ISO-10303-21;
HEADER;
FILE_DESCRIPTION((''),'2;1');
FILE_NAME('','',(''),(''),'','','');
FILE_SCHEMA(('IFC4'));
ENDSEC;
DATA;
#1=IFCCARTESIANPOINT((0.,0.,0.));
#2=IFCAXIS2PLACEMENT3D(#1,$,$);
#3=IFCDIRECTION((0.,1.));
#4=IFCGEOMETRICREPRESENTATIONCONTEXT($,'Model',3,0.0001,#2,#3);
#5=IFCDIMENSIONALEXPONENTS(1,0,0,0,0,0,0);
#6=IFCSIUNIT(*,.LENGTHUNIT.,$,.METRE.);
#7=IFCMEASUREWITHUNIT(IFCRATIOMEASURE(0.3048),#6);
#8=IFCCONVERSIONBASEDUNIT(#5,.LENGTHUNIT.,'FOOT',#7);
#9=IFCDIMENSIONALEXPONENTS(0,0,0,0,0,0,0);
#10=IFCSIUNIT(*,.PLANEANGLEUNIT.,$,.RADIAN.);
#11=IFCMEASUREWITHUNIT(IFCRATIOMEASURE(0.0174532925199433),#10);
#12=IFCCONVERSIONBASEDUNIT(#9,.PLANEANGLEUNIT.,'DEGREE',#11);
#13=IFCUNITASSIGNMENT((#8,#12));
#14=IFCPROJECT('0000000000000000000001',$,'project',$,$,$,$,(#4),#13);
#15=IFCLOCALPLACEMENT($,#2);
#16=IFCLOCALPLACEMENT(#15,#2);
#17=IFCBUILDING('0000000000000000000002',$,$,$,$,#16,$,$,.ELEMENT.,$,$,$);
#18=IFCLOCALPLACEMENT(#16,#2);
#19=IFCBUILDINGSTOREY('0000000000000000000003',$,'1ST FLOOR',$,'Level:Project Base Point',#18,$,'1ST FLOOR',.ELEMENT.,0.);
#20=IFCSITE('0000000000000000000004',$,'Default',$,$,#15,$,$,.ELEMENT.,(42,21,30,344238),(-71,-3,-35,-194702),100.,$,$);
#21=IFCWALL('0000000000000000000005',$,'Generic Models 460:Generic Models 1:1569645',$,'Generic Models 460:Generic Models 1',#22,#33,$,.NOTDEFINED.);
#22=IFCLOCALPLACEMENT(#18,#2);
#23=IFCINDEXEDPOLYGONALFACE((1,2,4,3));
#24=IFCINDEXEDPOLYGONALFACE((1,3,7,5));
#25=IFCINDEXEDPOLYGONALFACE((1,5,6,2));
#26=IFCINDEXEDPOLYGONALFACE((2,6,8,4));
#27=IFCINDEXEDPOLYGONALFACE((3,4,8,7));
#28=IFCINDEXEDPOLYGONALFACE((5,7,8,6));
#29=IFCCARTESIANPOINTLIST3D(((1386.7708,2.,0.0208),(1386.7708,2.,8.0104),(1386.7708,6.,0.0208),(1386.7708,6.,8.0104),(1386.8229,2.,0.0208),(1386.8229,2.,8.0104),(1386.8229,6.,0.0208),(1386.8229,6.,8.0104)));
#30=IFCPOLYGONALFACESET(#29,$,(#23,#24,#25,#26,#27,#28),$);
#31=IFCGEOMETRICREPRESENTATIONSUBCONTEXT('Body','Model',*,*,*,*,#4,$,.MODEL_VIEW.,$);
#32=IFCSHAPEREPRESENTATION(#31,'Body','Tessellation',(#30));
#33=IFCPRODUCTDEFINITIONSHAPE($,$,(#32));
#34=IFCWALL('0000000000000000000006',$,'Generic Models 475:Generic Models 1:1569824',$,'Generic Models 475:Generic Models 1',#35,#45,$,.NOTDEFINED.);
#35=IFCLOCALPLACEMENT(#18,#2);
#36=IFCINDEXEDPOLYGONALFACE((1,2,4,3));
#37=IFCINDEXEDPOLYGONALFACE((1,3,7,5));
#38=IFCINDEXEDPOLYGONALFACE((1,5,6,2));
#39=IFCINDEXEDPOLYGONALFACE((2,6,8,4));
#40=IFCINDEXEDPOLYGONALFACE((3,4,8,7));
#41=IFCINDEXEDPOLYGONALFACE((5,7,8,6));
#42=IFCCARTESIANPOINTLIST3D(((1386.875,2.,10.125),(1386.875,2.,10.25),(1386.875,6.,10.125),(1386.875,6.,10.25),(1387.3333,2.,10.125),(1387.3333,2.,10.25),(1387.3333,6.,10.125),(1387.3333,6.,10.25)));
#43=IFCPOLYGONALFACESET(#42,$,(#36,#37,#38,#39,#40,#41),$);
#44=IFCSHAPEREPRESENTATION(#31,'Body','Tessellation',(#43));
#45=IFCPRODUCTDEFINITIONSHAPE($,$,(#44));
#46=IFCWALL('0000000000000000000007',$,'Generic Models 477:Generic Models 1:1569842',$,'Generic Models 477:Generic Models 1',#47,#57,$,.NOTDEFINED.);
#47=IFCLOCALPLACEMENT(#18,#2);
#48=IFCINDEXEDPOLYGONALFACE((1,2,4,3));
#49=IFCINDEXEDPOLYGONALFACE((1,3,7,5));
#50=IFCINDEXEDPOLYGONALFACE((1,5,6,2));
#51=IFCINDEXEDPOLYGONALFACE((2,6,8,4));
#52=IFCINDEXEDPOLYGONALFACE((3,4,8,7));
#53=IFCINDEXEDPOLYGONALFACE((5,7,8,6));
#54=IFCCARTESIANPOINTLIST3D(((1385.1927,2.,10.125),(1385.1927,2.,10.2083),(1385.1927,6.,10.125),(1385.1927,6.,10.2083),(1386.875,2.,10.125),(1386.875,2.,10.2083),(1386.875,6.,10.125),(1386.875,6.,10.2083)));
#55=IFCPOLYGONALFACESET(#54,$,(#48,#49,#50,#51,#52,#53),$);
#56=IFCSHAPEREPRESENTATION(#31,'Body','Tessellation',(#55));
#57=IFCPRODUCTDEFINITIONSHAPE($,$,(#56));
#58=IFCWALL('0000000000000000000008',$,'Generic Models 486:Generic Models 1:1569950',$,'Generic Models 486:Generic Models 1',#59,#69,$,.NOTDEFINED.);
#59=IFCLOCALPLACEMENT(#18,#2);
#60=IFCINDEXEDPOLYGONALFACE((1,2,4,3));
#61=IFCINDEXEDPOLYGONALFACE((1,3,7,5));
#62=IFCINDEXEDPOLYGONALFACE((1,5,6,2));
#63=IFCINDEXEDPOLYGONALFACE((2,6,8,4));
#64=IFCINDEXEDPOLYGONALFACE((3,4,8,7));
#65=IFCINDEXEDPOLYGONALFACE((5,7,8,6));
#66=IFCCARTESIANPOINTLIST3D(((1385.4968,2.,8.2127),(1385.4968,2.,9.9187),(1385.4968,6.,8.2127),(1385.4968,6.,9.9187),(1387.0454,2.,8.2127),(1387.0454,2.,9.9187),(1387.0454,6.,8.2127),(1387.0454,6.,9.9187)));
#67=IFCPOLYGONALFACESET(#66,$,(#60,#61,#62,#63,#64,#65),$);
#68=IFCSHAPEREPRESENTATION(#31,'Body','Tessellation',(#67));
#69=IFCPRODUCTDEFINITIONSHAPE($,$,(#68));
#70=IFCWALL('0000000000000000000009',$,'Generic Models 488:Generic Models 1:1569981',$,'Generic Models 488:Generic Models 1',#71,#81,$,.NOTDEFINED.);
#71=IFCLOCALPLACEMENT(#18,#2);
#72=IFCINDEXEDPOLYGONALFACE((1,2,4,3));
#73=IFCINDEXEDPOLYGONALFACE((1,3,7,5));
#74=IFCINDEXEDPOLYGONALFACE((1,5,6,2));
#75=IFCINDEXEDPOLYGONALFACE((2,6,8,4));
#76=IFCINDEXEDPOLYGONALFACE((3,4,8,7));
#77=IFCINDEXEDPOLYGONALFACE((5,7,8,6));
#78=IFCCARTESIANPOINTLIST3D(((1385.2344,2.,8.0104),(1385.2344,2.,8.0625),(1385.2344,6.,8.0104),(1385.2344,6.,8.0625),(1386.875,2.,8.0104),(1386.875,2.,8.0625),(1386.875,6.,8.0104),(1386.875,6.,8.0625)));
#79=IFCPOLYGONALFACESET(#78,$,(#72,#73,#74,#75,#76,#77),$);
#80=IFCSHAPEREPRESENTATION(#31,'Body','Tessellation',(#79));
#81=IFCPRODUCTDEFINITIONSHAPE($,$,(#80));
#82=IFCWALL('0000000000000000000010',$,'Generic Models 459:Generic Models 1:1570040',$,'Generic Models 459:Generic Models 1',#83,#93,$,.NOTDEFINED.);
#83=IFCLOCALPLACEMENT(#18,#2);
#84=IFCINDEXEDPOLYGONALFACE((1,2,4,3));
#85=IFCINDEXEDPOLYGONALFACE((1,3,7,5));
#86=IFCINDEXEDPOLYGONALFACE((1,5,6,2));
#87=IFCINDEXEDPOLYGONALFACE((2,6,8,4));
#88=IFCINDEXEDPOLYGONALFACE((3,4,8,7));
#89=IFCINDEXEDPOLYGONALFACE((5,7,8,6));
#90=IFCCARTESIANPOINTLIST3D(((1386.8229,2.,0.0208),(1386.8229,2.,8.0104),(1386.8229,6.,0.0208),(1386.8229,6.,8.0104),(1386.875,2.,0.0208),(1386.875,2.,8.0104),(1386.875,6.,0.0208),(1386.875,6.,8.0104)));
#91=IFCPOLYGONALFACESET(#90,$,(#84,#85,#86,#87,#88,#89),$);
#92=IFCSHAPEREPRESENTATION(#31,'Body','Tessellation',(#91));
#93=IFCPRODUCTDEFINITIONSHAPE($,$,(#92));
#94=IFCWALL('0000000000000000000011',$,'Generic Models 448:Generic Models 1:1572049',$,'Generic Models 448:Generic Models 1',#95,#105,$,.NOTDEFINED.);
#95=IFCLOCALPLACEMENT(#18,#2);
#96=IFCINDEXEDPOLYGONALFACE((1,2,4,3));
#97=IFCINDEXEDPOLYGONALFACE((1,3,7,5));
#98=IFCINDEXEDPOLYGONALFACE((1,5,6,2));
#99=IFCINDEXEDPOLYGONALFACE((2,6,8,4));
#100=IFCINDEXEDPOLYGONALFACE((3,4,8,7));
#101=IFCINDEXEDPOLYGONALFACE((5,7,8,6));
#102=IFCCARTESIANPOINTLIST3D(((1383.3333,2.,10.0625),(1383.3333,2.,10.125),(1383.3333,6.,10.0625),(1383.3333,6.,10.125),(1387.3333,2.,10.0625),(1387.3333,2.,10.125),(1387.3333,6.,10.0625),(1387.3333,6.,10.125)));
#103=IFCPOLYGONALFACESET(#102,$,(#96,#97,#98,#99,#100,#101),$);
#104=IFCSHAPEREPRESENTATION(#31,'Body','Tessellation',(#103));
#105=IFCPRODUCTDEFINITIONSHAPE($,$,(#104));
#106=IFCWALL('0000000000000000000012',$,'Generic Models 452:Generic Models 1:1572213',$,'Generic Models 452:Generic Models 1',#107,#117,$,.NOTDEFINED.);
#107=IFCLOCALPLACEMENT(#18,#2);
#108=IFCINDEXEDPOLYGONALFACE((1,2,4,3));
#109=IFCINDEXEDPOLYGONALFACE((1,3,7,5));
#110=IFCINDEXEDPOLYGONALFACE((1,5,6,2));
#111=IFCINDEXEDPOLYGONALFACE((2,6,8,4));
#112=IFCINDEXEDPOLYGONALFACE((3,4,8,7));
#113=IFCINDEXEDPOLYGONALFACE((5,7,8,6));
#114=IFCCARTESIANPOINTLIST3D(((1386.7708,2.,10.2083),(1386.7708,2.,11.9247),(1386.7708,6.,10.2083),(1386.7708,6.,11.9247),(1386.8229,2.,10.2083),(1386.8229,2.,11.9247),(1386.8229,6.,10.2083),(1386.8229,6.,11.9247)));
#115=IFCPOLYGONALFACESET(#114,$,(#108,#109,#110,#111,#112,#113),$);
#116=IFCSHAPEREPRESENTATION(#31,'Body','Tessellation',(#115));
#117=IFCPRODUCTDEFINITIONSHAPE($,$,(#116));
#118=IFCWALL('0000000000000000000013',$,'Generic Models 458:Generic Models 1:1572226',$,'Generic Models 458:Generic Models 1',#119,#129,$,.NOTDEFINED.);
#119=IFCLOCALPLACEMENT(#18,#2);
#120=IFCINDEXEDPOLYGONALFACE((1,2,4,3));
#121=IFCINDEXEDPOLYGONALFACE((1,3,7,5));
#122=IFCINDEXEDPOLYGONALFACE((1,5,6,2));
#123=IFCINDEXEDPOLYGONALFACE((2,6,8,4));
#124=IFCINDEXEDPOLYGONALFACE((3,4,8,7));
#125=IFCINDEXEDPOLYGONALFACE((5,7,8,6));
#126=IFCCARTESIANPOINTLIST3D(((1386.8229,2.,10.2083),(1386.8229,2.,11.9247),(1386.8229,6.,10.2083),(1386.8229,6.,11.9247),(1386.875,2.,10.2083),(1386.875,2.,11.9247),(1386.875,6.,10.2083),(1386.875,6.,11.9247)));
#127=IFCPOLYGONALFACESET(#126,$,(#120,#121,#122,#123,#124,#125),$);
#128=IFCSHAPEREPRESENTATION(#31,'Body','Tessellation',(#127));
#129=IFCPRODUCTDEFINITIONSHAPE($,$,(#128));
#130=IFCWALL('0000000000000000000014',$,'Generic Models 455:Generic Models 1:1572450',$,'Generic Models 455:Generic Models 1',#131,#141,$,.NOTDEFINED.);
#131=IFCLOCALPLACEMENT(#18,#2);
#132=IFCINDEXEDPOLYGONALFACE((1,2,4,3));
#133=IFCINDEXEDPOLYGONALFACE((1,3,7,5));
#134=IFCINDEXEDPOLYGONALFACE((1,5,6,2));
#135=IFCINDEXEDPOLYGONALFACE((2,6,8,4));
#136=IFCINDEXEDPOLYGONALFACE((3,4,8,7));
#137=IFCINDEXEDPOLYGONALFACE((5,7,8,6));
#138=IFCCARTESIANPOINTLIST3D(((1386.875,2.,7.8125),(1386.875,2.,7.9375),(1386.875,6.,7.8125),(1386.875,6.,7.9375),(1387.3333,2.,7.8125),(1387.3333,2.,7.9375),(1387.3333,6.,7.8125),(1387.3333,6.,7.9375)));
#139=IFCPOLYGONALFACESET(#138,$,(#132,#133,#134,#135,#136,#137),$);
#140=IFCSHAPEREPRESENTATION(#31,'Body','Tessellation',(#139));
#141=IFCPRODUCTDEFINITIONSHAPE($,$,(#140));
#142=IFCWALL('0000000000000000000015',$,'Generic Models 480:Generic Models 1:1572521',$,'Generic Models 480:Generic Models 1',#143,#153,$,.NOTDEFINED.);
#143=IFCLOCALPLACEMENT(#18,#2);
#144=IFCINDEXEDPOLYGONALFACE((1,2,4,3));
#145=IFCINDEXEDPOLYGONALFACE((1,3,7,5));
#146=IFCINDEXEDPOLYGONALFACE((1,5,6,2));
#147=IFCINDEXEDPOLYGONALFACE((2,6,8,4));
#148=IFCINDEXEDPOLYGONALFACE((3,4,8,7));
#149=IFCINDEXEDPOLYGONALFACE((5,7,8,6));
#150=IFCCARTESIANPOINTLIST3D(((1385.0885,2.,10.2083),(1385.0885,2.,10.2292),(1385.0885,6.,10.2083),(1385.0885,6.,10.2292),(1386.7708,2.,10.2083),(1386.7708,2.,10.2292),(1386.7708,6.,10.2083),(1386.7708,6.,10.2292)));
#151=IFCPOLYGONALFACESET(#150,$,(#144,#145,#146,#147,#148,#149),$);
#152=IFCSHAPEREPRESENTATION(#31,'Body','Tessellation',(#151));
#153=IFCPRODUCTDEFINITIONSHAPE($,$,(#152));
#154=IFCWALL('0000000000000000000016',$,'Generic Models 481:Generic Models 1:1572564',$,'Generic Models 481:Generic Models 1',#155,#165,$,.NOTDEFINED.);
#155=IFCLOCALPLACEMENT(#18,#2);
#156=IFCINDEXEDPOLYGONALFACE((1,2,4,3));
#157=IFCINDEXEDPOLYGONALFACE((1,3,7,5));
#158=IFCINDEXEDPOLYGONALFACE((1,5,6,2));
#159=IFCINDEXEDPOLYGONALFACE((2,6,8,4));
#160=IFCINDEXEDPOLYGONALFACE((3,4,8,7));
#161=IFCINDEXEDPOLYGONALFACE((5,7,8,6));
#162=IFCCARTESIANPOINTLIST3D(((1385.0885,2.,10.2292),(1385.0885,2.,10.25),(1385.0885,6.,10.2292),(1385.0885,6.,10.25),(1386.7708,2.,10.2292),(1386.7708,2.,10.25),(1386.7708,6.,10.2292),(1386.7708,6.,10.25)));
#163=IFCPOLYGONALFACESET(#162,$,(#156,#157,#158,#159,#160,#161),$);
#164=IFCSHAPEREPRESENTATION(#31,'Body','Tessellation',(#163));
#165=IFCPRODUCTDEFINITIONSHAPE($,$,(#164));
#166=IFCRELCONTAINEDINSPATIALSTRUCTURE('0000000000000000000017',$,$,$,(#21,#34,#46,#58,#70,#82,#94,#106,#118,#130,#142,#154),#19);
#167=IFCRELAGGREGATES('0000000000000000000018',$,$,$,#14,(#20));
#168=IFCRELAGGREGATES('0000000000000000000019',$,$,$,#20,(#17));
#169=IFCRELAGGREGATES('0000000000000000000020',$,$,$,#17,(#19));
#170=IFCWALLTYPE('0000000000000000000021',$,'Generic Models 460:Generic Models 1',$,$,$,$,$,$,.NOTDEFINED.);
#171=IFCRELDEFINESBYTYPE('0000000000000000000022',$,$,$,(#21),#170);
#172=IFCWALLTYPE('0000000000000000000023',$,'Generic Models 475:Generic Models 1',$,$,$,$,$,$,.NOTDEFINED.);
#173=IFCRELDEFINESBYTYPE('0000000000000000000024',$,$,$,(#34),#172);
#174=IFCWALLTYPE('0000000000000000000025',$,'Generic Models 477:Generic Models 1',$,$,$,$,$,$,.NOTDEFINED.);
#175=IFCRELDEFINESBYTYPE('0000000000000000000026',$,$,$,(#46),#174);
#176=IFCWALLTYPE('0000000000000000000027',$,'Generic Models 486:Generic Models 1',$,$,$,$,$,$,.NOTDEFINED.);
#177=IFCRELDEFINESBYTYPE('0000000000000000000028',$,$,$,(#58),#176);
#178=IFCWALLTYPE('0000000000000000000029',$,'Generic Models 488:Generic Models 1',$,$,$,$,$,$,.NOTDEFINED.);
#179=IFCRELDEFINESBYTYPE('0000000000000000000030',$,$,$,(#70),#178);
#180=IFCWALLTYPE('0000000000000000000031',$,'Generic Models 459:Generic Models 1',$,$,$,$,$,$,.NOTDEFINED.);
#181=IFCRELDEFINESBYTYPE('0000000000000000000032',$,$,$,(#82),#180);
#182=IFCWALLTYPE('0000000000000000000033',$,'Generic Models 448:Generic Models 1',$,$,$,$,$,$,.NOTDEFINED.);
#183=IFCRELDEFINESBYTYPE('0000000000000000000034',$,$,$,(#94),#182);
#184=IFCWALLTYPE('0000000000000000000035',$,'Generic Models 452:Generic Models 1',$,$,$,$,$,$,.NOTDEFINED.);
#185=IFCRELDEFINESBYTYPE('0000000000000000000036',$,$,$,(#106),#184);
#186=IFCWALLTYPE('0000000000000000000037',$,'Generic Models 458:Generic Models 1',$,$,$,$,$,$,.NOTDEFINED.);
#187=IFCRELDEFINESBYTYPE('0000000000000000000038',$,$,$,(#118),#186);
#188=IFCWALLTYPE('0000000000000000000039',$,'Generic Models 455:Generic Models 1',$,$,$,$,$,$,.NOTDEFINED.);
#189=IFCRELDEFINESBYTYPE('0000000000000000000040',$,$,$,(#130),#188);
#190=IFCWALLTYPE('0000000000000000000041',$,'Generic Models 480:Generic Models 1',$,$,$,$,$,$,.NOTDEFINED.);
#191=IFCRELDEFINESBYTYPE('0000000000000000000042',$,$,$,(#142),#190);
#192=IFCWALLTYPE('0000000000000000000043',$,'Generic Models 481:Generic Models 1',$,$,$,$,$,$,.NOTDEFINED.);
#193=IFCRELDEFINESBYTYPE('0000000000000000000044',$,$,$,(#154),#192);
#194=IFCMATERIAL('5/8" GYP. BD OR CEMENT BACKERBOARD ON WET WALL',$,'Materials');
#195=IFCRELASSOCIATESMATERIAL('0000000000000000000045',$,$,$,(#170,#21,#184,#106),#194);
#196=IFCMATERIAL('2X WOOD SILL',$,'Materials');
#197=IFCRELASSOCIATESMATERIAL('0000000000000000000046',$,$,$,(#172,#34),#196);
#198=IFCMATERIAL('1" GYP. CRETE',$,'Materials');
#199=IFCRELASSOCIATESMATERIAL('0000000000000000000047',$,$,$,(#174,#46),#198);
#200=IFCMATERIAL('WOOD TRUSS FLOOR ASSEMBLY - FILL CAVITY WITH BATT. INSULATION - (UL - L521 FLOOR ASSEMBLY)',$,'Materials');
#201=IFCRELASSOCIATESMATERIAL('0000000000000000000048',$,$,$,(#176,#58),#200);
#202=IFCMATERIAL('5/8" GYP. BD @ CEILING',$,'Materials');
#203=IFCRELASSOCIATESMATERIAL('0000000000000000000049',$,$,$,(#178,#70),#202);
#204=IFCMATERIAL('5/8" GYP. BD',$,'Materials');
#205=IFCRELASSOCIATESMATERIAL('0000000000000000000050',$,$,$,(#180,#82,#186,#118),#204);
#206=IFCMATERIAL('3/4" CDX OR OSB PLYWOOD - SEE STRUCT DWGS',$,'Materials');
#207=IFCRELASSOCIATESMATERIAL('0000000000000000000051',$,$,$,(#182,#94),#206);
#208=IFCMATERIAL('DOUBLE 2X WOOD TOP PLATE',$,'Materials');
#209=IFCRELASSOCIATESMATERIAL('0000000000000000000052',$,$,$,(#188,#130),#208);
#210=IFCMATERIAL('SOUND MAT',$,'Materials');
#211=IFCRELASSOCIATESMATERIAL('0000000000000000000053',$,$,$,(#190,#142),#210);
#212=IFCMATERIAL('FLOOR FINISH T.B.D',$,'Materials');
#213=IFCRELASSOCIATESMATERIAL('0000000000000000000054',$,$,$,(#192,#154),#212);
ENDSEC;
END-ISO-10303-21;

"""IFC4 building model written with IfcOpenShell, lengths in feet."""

from ifc_helpers import new_model, entity, si_unit, converted_unit, direction, frame, frame_2d, origin, origin_2d_with_axis, place, context, subcontext, project, spatial, rectangle, extrude, material, type_object, element, save


model = new_model("IFC4")

# Units and contexts
model_context = context("Model", 3, precision=0.0001, world=origin(), true_north=direction((0.0, 1.0)))
body_context = subcontext(model_context, "Body", "Model", "MODEL_VIEW")
ifc_project = project(units=[converted_unit("LENGTHUNIT", "FOOT", entity("IfcRatioMeasure", 0.3048), si_unit("LENGTHUNIT", "METRE"), dimensions=[1, 0, 0, 0, 0, 0, 0]), converted_unit("PLANEANGLEUNIT", "DEGREE", entity("IfcRatioMeasure", 0.0174532925199433), si_unit("PLANEANGLEUNIT", "RADIAN"), dimensions=[0, 0, 0, 0, 0, 0, 0])], contexts=[model_context])

# Site, building, storey
site_placement = place(None, origin())
site = spatial("IfcSite", under=ifc_project, at=site_placement, Name="Default", CompositionType="ELEMENT", RefLatitude=(42, 21, 30, 344238), RefLongitude=(-71, -3, -35, -194702), RefElevation=100.0)
building_placement = place(site_placement, origin())
building = spatial("IfcBuilding", under=site, at=building_placement, CompositionType="ELEMENT")
storey_placement = place(building_placement, origin())
storey = spatial("IfcBuildingStorey", under=building, at=storey_placement, Name="1ST FLOOR", ObjectType="Level:Project Base Point", LongName="1ST FLOOR", CompositionType="ELEMENT", Elevation=0.0)

# Walls
ifc_material_1 = material(Name="5/8\" GYP. BD", Category="Materials")
ifc_material_2 = material(Name="5/8\" GYP. BD OR CEMENT BACKERBOARD ON WET WALL", Category="Materials")
ifc_material_3 = material(Name="2X WOOD SILL", Category="Materials")
ifc_material_4 = material(Name="1\" GYP. CRETE", Category="Materials")
ifc_material_5 = material(Name="5/8\" GYP. BD @ CEILING", Category="Materials")
ifc_material_6 = material(Name="DOUBLE 2X WOOD TOP PLATE", Category="Materials")
wall_type_1 = type_object("IfcWallType", Name="Generic Models 460:Generic Models 1", PredefinedType="NOTDEFINED", material=ifc_material_2)
wall_1_placement = place(storey_placement, frame((1386.7708, 2.0, 0.0208), z_axis=(0.0, 0.0, 1.0), x_axis=(0.0, 1.0, 0.0)))
element("IfcWall", 1, at=wall_1_placement, inside=storey, type_object=wall_type_1, material=ifc_material_2, Name="Generic Models 460:Generic Models 1:1569645", ObjectType="Generic Models 460:Generic Models 1", PredefinedType="NOTDEFINED", context=body_context, shape_type="SweptSolid", body=[
    extrude(rectangle(XDim=4.0, YDim=0.0521, at=frame_2d((0.0, 0.0), x_axis=(1.0, 0.0))), frame((2.0, -0.026, 0.0)), (0.0, 0.0, 1.0), 7.9896),
])
wall_type_2 = type_object("IfcWallType", Name="Generic Models 475:Generic Models 1", PredefinedType="NOTDEFINED", material=ifc_material_3)
wall_2_placement = place(storey_placement, frame((1386.875, 2.0, 10.125), z_axis=(0.0, 0.0, 1.0), x_axis=(0.0, 1.0, 0.0)))
element("IfcWall", 2, at=wall_2_placement, inside=storey, type_object=wall_type_2, material=ifc_material_3, Name="Generic Models 475:Generic Models 1:1569824", ObjectType="Generic Models 475:Generic Models 1", PredefinedType="NOTDEFINED", context=body_context, shape_type="SweptSolid", body=[
    extrude(rectangle(XDim=4.0, YDim=0.4583, at=frame_2d((0.0, 0.0), x_axis=(1.0, 0.0))), frame((2.0, -0.2292, 0.0)), (0.0, 0.0, 1.0), 0.125),
])
wall_type_3 = type_object("IfcWallType", Name="Generic Models 477:Generic Models 1", PredefinedType="NOTDEFINED", material=ifc_material_4)
wall_3_placement = place(storey_placement, frame((1385.1927, 2.0, 10.125), z_axis=(0.0, 0.0, 1.0), x_axis=(0.0, 1.0, 0.0)))
element("IfcWall", 3, at=wall_3_placement, inside=storey, type_object=wall_type_3, material=ifc_material_4, Name="Generic Models 477:Generic Models 1:1569842", ObjectType="Generic Models 477:Generic Models 1", PredefinedType="NOTDEFINED", context=body_context, shape_type="SweptSolid", body=[
    extrude(rectangle(XDim=4.0, YDim=1.6823, at=frame_2d((0.0, 0.0), x_axis=(1.0, 0.0))), frame((2.0, -0.8411, 0.0)), (0.0, 0.0, 1.0), 0.0833),
])
ifc_material_7 = material(Name="WOOD TRUSS FLOOR ASSEMBLY - FILL CAVITY WITH BATT. INSULATION - (UL - L521 FLOOR ASSEMBLY)", Category="Materials")
wall_type_4 = type_object("IfcWallType", Name="Generic Models 486:Generic Models 1", PredefinedType="NOTDEFINED", material=ifc_material_7)
wall_4_placement = place(storey_placement, frame((1385.4968, 2.0, 8.2127), z_axis=(0.0, 0.0, 1.0), x_axis=(0.0, 1.0, 0.0)))
element("IfcWall", 4, at=wall_4_placement, inside=storey, type_object=wall_type_4, material=ifc_material_7, Name="Generic Models 486:Generic Models 1:1569950", ObjectType="Generic Models 486:Generic Models 1", PredefinedType="NOTDEFINED", context=body_context, shape_type="SweptSolid", body=[
    extrude(rectangle(XDim=4.0, YDim=1.5487, at=frame_2d((0.0, 0.0), x_axis=(1.0, 0.0))), frame((2.0, -0.7743, 0.0)), (0.0, 0.0, 1.0), 1.706),
])
wall_type_5 = type_object("IfcWallType", Name="Generic Models 488:Generic Models 1", PredefinedType="NOTDEFINED", material=ifc_material_5)
wall_5_placement = place(storey_placement, frame((1385.2344, 2.0, 8.0104), z_axis=(0.0, 0.0, 1.0), x_axis=(0.0, 1.0, 0.0)))
element("IfcWall", 5, at=wall_5_placement, inside=storey, type_object=wall_type_5, material=ifc_material_5, Name="Generic Models 488:Generic Models 1:1569981", ObjectType="Generic Models 488:Generic Models 1", PredefinedType="NOTDEFINED", context=body_context, shape_type="SweptSolid", body=[
    extrude(rectangle(XDim=4.0, YDim=1.6406, at=frame_2d((0.0, 0.0), x_axis=(1.0, 0.0))), frame((2.0, -0.8203, 0.0)), (0.0, 0.0, 1.0), 0.0521),
])
wall_type_6 = type_object("IfcWallType", Name="Generic Models 459:Generic Models 1", PredefinedType="NOTDEFINED", material=ifc_material_1)
wall_6_placement = place(storey_placement, frame((1386.8229, 2.0, 0.0208), z_axis=(0.0, 0.0, 1.0), x_axis=(0.0, 1.0, 0.0)))
element("IfcWall", 6, at=wall_6_placement, inside=storey, type_object=wall_type_6, material=ifc_material_1, Name="Generic Models 459:Generic Models 1:1570040", ObjectType="Generic Models 459:Generic Models 1", PredefinedType="NOTDEFINED", context=body_context, shape_type="SweptSolid", body=[
    extrude(rectangle(XDim=4.0, YDim=0.0521, at=frame_2d((0.0, 0.0), x_axis=(1.0, 0.0))), frame((2.0, -0.026, 0.0)), (0.0, 0.0, 1.0), 7.9896),
])
ifc_material_8 = material(Name="3/4\" CDX OR OSB PLYWOOD - SEE STRUCT DWGS", Category="Materials")
wall_type_7 = type_object("IfcWallType", Name="Generic Models 448:Generic Models 1", PredefinedType="NOTDEFINED", material=ifc_material_8)
wall_7_placement = place(storey_placement, frame((1383.3333, 2.0, 10.0625), z_axis=(0.0, 0.0, 1.0), x_axis=(0.0, 1.0, 0.0)))
element("IfcWall", 7, at=wall_7_placement, inside=storey, type_object=wall_type_7, material=ifc_material_8, Name="Generic Models 448:Generic Models 1:1572049", ObjectType="Generic Models 448:Generic Models 1", PredefinedType="NOTDEFINED", context=body_context, shape_type="SweptSolid", body=[
    extrude(rectangle(XDim=4.0, YDim=4.0, at=frame_2d((0.0, 0.0), x_axis=(1.0, 0.0))), frame((2.0, -2.0, 0.0)), (0.0, 0.0, 1.0), 0.0625),
])
wall_type_8 = type_object("IfcWallType", Name="Generic Models 452:Generic Models 1", PredefinedType="NOTDEFINED", material=ifc_material_2)
wall_8_placement = place(storey_placement, frame((1386.7708, 2.0, 10.2083), z_axis=(0.0, 0.0, 1.0), x_axis=(0.0, 1.0, 0.0)))
element("IfcWall", 8, at=wall_8_placement, inside=storey, type_object=wall_type_8, material=ifc_material_2, Name="Generic Models 452:Generic Models 1:1572213", ObjectType="Generic Models 452:Generic Models 1", PredefinedType="NOTDEFINED", context=body_context, shape_type="SweptSolid", body=[
    extrude(rectangle(XDim=4.0, YDim=0.0521, at=frame_2d((0.0, 0.0), x_axis=(1.0, 0.0))), frame((2.0, -0.026, 0.0)), (0.0, 0.0, 1.0), 1.7163),
])
wall_type_9 = type_object("IfcWallType", Name="Generic Models 458:Generic Models 1", PredefinedType="NOTDEFINED", material=ifc_material_1)
wall_9_placement = place(storey_placement, frame((1386.8229, 2.0, 10.2083), z_axis=(0.0, 0.0, 1.0), x_axis=(0.0, 1.0, 0.0)))
element("IfcWall", 9, at=wall_9_placement, inside=storey, type_object=wall_type_9, material=ifc_material_1, Name="Generic Models 458:Generic Models 1:1572226", ObjectType="Generic Models 458:Generic Models 1", PredefinedType="NOTDEFINED", context=body_context, shape_type="SweptSolid", body=[
    extrude(rectangle(XDim=4.0, YDim=0.0521, at=frame_2d((0.0, 0.0), x_axis=(1.0, 0.0))), frame((2.0, -0.026, 0.0)), (0.0, 0.0, 1.0), 1.7163),
])
wall_type_10 = type_object("IfcWallType", Name="Generic Models 455:Generic Models 1", PredefinedType="NOTDEFINED", material=ifc_material_6)
wall_10_placement = place(storey_placement, frame((1386.875, 2.0, 7.8125), z_axis=(0.0, 0.0, 1.0), x_axis=(0.0, 1.0, 0.0)))
element("IfcWall", 10, at=wall_10_placement, inside=storey, type_object=wall_type_10, material=ifc_material_6, Name="Generic Models 455:Generic Models 1:1572450", ObjectType="Generic Models 455:Generic Models 1", PredefinedType="NOTDEFINED", context=body_context, shape_type="SweptSolid", body=[
    extrude(rectangle(XDim=4.0, YDim=0.4583, at=frame_2d((0.0, 0.0), x_axis=(1.0, 0.0))), frame((2.0, -0.2292, 0.0)), (0.0, 0.0, 1.0), 0.125),
])
ifc_material_9 = material(Name="SOUND MAT", Category="Materials")
wall_type_11 = type_object("IfcWallType", Name="Generic Models 480:Generic Models 1", PredefinedType="NOTDEFINED", material=ifc_material_9)
wall_11_placement = place(storey_placement, frame((1385.0885, 2.0, 10.2083), z_axis=(0.0, 0.0, 1.0), x_axis=(0.0, 1.0, 0.0)))
element("IfcWall", 11, at=wall_11_placement, inside=storey, type_object=wall_type_11, material=ifc_material_9, Name="Generic Models 480:Generic Models 1:1572521", ObjectType="Generic Models 480:Generic Models 1", PredefinedType="NOTDEFINED", context=body_context, shape_type="SweptSolid", body=[
    extrude(rectangle(XDim=4.0, YDim=1.6823, at=origin_2d_with_axis()), frame((2.0, -0.8411, 0.0)), (0.0, 0.0, 1.0), 0.0208),
])
ifc_material_10 = material(Name="FLOOR FINISH T.B.D", Category="Materials")
wall_type_12 = type_object("IfcWallType", Name="Generic Models 481:Generic Models 1", PredefinedType="NOTDEFINED", material=ifc_material_10)
wall_12_placement = place(storey_placement, frame((1385.0885, 2.0, 10.2292), z_axis=(0.0, 0.0, 1.0), x_axis=(0.0, 1.0, 0.0)))
element("IfcWall", 12, at=wall_12_placement, inside=storey, type_object=wall_type_12, material=ifc_material_10, Name="Generic Models 481:Generic Models 1:1572564", ObjectType="Generic Models 481:Generic Models 1", PredefinedType="NOTDEFINED", context=body_context, shape_type="SweptSolid", body=[
    extrude(rectangle(XDim=4.0, YDim=1.6823, at=origin_2d_with_axis()), frame((2.0, -0.8411, 0.0)), (0.0, 0.0, 1.0), 0.0208),
])

save(model, "model.ifc")
